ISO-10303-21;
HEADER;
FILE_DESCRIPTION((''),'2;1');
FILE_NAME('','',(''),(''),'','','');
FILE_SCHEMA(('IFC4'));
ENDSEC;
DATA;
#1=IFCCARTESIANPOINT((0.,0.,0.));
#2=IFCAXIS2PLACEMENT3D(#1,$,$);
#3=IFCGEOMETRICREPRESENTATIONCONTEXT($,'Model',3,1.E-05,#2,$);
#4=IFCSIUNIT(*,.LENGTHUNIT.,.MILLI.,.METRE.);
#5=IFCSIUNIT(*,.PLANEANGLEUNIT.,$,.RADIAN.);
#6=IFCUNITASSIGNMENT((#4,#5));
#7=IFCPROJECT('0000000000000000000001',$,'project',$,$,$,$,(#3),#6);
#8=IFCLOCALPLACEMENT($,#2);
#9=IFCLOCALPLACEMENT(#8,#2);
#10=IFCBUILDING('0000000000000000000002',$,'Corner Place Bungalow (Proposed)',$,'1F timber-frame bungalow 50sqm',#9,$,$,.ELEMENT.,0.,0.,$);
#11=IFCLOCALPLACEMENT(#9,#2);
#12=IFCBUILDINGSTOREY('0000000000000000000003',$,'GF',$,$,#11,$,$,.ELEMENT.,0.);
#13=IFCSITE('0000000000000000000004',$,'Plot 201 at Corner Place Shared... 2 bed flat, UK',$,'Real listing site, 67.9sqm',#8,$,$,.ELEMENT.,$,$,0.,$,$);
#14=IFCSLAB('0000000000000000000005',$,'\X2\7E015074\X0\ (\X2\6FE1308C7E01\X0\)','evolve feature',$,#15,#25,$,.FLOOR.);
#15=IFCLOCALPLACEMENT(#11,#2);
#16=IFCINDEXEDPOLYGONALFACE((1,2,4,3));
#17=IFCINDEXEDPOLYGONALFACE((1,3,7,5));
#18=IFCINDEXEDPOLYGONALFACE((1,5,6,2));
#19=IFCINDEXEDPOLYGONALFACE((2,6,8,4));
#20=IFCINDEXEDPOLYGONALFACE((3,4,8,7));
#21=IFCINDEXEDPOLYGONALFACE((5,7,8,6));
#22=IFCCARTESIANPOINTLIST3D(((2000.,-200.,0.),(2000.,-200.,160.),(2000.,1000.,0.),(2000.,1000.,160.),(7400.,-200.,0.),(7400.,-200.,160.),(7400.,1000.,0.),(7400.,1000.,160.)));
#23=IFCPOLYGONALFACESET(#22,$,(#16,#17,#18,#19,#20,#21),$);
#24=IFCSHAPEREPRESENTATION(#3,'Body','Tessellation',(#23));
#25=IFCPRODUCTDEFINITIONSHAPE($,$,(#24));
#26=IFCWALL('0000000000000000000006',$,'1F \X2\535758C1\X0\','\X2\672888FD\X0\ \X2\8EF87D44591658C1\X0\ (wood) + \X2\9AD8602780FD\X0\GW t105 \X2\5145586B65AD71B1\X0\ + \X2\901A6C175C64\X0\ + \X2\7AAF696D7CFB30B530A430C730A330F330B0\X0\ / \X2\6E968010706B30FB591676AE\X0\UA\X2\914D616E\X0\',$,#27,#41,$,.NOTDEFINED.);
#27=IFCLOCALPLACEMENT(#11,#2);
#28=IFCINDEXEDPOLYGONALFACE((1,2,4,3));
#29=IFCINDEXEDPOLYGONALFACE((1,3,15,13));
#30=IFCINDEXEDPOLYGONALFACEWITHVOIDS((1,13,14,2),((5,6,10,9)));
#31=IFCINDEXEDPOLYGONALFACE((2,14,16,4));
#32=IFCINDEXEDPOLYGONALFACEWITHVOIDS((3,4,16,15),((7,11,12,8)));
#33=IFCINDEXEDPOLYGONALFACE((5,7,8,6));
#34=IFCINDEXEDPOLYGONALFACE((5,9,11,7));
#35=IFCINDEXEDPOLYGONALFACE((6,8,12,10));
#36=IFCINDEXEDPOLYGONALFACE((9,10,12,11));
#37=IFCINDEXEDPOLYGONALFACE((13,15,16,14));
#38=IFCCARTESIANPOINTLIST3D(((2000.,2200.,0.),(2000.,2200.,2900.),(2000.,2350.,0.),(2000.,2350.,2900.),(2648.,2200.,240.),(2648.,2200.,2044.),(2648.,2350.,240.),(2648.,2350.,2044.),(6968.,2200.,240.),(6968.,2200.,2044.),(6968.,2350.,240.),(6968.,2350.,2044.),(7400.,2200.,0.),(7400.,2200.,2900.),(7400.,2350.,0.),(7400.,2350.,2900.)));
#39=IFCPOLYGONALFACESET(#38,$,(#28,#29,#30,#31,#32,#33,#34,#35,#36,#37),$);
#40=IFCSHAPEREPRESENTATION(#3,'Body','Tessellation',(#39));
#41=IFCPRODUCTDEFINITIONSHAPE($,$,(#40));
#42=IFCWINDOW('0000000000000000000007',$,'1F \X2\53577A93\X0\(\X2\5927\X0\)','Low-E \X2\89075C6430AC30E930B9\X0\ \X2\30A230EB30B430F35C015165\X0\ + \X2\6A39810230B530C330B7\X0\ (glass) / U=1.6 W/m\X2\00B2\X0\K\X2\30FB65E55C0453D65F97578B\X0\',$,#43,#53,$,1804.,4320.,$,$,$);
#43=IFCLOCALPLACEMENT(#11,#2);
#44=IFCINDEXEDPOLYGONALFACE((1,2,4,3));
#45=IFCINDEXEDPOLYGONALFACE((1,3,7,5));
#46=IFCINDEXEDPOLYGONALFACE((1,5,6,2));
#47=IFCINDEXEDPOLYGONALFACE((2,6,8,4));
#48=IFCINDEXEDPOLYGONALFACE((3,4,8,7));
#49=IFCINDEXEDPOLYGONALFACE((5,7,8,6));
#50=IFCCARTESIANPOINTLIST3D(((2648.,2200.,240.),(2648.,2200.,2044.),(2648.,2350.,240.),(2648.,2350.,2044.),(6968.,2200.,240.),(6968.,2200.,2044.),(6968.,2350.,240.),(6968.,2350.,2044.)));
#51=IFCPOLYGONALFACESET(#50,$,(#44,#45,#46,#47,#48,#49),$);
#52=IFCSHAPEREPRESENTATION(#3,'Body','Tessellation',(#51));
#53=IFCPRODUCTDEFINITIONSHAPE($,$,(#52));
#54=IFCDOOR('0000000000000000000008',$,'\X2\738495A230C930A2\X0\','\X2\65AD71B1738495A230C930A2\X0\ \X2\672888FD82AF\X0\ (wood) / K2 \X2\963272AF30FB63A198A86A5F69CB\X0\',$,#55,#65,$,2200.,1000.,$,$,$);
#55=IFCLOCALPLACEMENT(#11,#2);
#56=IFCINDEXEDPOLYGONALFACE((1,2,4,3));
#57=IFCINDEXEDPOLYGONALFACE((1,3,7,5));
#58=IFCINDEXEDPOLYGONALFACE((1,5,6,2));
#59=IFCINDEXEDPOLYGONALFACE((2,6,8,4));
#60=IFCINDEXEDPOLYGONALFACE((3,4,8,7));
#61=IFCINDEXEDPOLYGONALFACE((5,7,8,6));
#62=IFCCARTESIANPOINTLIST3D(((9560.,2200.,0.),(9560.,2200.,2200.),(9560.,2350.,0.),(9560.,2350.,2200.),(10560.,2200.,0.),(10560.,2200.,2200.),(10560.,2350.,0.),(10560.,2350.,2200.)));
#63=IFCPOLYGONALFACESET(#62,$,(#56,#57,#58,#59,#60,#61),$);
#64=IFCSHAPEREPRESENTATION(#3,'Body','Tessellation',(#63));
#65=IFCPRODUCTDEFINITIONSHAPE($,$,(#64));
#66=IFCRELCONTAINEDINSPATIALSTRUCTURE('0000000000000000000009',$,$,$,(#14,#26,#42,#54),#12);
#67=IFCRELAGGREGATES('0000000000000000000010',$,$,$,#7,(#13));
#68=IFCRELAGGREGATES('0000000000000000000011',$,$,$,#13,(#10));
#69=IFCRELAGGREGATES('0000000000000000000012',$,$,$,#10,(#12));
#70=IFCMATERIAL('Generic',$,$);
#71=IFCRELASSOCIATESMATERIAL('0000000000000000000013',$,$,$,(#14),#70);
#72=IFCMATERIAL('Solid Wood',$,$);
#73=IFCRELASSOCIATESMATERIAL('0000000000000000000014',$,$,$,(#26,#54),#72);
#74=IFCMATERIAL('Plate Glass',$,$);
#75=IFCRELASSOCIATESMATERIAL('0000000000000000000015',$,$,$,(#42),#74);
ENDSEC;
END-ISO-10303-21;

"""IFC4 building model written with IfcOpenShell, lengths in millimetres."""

from ifc_helpers import new_model, si_unit, frame, frame_2d, origin, place, context, project, spatial, rectangle, extrude, material, element, fill, save


model = new_model("IFC4")

# Units and contexts
model_context = context("Model", 3, precision=1e-05, world=origin())
ifc_project = project(units=[si_unit("LENGTHUNIT", "METRE", prefix="MILLI"), si_unit("PLANEANGLEUNIT", "RADIAN")], contexts=[model_context])

# Site, building, storey
site_placement = place(None, origin())
site = spatial("IfcSite", under=ifc_project, at=site_placement, Name="Plot 201 at Corner Place Shared... 2 bed flat, UK", ObjectType="Real listing site, 67.9sqm", CompositionType="ELEMENT", RefElevation=0.0)
building_placement = place(site_placement, origin())
building = spatial("IfcBuilding", under=site, at=building_placement, Name="Corner Place Bungalow (Proposed)", ObjectType="1F timber-frame bungalow 50sqm", CompositionType="ELEMENT", ElevationOfRefHeight=0.0, ElevationOfTerrain=0.0)
storey_placement = place(building_placement, origin())
storey = spatial("IfcBuildingStorey", under=building, at=storey_placement, Name="GF", CompositionType="ELEMENT", Elevation=0.0)

# Slab
ifc_material_1 = material(Name="Solid Wood")
ifc_material_2 = material(Name="Generic")
slab_1_placement = place(storey_placement, frame((1000.0, -100.0, 0.0)))
element("IfcSlab", 1, at=slab_1_placement, inside=storey, material=ifc_material_2, Name="縁側 (濡れ縁)", Description="evolve feature", PredefinedType="FLOOR", context=model_context, shape_type="SweptSolid", body=[
    extrude(rectangle(XDim=5400.0, YDim=1200.0, at=frame_2d((2700.0, 600.0))), frame((1000.0, -100.0, 0.0)), (0.0, 0.0, 1.0), 160.0),
])

# Wall, openings, window, door
wall_1_placement = place(storey_placement, frame((1000.0, 1100.0, 0.0)))
wall_1 = element("IfcWall", 2, at=wall_1_placement, inside=storey, material=ifc_material_1, Name="1F 南壁", Description="木製 軸組外壁 (wood) + 高性能GW t105 充填断熱 + 通気層 + 窯業系サイディング / 準耐火・外皮UA配慮", PredefinedType="NOTDEFINED", context=model_context, shape_type="SweptSolid", body=[
    extrude(rectangle(XDim=5400.0, YDim=150.0, at=frame_2d((2700.0, 75.0))), frame((1000.0, 1100.0, 0.0)), (0.0, 0.0, 1.0), 2900.0),
])
opening_1_placement = place(storey_placement, frame((1324.0, 1100.0, 120.0)))
opening_1 = element("IfcOpeningElement", 3, at=opening_1_placement, cuts=wall_1, PredefinedType="NOTDEFINED", context=model_context, shape_type="SweptSolid", body=[
    extrude(rectangle(XDim=4320.0, YDim=150.0, at=frame_2d((2160.0, 75.0))), frame((1324.0, 1100.0, 120.0)), (0.0, 0.0, 1.0), 1804.0),
])
opening_2_placement = place(storey_placement, frame((4780.0, 1100.0, 0.0)))
opening_2 = element("IfcOpeningElement", 4, at=opening_2_placement, cuts=wall_1, PredefinedType="NOTDEFINED", context=model_context, shape_type="SweptSolid", body=[
    extrude(rectangle(XDim=1000.0, YDim=150.0, at=frame_2d((500.0, 75.0))), frame((4780.0, 1100.0, 0.0)), (0.0, 0.0, 1.0), 2200.0),
])
ifc_material_3 = material(Name="Plate Glass")
window_1_placement = place(storey_placement, frame((1324.0, 1100.0, 120.0)))
window_1 = element("IfcWindow", 5, at=window_1_placement, inside=storey, material=ifc_material_3, Name="1F 南窓(大)", Description="Low-E 複層ガラス アルゴン封入 + 樹脂サッシ (glass) / U=1.6 W/m²K・日射取得型", OverallHeight=1804.0, OverallWidth=4320.0, context=model_context, shape_type="SweptSolid", body=[
    extrude(rectangle(XDim=4320.0, YDim=150.0, at=frame_2d((2160.0, 75.0))), frame((1324.0, 1100.0, 120.0)), (0.0, 0.0, 1.0), 1804.0),
])
fill(opening_1, window_1)
door_placement = place(storey_placement, frame((4780.0, 1100.0, 0.0)))
door = element("IfcDoor", 6, at=door_placement, inside=storey, material=ifc_material_1, Name="玄関ドア", Description="断熱玄関ドア 木製芯 (wood) / K2 防犯・採風機構", OverallHeight=2200.0, OverallWidth=1000.0, context=model_context, shape_type="SweptSolid", body=[
    extrude(rectangle(XDim=1000.0, YDim=150.0, at=frame_2d((500.0, 75.0))), frame((4780.0, 1100.0, 0.0)), (0.0, 0.0, 1.0), 2200.0),
])
fill(opening_2, door)

save(model, "model.ifc")
